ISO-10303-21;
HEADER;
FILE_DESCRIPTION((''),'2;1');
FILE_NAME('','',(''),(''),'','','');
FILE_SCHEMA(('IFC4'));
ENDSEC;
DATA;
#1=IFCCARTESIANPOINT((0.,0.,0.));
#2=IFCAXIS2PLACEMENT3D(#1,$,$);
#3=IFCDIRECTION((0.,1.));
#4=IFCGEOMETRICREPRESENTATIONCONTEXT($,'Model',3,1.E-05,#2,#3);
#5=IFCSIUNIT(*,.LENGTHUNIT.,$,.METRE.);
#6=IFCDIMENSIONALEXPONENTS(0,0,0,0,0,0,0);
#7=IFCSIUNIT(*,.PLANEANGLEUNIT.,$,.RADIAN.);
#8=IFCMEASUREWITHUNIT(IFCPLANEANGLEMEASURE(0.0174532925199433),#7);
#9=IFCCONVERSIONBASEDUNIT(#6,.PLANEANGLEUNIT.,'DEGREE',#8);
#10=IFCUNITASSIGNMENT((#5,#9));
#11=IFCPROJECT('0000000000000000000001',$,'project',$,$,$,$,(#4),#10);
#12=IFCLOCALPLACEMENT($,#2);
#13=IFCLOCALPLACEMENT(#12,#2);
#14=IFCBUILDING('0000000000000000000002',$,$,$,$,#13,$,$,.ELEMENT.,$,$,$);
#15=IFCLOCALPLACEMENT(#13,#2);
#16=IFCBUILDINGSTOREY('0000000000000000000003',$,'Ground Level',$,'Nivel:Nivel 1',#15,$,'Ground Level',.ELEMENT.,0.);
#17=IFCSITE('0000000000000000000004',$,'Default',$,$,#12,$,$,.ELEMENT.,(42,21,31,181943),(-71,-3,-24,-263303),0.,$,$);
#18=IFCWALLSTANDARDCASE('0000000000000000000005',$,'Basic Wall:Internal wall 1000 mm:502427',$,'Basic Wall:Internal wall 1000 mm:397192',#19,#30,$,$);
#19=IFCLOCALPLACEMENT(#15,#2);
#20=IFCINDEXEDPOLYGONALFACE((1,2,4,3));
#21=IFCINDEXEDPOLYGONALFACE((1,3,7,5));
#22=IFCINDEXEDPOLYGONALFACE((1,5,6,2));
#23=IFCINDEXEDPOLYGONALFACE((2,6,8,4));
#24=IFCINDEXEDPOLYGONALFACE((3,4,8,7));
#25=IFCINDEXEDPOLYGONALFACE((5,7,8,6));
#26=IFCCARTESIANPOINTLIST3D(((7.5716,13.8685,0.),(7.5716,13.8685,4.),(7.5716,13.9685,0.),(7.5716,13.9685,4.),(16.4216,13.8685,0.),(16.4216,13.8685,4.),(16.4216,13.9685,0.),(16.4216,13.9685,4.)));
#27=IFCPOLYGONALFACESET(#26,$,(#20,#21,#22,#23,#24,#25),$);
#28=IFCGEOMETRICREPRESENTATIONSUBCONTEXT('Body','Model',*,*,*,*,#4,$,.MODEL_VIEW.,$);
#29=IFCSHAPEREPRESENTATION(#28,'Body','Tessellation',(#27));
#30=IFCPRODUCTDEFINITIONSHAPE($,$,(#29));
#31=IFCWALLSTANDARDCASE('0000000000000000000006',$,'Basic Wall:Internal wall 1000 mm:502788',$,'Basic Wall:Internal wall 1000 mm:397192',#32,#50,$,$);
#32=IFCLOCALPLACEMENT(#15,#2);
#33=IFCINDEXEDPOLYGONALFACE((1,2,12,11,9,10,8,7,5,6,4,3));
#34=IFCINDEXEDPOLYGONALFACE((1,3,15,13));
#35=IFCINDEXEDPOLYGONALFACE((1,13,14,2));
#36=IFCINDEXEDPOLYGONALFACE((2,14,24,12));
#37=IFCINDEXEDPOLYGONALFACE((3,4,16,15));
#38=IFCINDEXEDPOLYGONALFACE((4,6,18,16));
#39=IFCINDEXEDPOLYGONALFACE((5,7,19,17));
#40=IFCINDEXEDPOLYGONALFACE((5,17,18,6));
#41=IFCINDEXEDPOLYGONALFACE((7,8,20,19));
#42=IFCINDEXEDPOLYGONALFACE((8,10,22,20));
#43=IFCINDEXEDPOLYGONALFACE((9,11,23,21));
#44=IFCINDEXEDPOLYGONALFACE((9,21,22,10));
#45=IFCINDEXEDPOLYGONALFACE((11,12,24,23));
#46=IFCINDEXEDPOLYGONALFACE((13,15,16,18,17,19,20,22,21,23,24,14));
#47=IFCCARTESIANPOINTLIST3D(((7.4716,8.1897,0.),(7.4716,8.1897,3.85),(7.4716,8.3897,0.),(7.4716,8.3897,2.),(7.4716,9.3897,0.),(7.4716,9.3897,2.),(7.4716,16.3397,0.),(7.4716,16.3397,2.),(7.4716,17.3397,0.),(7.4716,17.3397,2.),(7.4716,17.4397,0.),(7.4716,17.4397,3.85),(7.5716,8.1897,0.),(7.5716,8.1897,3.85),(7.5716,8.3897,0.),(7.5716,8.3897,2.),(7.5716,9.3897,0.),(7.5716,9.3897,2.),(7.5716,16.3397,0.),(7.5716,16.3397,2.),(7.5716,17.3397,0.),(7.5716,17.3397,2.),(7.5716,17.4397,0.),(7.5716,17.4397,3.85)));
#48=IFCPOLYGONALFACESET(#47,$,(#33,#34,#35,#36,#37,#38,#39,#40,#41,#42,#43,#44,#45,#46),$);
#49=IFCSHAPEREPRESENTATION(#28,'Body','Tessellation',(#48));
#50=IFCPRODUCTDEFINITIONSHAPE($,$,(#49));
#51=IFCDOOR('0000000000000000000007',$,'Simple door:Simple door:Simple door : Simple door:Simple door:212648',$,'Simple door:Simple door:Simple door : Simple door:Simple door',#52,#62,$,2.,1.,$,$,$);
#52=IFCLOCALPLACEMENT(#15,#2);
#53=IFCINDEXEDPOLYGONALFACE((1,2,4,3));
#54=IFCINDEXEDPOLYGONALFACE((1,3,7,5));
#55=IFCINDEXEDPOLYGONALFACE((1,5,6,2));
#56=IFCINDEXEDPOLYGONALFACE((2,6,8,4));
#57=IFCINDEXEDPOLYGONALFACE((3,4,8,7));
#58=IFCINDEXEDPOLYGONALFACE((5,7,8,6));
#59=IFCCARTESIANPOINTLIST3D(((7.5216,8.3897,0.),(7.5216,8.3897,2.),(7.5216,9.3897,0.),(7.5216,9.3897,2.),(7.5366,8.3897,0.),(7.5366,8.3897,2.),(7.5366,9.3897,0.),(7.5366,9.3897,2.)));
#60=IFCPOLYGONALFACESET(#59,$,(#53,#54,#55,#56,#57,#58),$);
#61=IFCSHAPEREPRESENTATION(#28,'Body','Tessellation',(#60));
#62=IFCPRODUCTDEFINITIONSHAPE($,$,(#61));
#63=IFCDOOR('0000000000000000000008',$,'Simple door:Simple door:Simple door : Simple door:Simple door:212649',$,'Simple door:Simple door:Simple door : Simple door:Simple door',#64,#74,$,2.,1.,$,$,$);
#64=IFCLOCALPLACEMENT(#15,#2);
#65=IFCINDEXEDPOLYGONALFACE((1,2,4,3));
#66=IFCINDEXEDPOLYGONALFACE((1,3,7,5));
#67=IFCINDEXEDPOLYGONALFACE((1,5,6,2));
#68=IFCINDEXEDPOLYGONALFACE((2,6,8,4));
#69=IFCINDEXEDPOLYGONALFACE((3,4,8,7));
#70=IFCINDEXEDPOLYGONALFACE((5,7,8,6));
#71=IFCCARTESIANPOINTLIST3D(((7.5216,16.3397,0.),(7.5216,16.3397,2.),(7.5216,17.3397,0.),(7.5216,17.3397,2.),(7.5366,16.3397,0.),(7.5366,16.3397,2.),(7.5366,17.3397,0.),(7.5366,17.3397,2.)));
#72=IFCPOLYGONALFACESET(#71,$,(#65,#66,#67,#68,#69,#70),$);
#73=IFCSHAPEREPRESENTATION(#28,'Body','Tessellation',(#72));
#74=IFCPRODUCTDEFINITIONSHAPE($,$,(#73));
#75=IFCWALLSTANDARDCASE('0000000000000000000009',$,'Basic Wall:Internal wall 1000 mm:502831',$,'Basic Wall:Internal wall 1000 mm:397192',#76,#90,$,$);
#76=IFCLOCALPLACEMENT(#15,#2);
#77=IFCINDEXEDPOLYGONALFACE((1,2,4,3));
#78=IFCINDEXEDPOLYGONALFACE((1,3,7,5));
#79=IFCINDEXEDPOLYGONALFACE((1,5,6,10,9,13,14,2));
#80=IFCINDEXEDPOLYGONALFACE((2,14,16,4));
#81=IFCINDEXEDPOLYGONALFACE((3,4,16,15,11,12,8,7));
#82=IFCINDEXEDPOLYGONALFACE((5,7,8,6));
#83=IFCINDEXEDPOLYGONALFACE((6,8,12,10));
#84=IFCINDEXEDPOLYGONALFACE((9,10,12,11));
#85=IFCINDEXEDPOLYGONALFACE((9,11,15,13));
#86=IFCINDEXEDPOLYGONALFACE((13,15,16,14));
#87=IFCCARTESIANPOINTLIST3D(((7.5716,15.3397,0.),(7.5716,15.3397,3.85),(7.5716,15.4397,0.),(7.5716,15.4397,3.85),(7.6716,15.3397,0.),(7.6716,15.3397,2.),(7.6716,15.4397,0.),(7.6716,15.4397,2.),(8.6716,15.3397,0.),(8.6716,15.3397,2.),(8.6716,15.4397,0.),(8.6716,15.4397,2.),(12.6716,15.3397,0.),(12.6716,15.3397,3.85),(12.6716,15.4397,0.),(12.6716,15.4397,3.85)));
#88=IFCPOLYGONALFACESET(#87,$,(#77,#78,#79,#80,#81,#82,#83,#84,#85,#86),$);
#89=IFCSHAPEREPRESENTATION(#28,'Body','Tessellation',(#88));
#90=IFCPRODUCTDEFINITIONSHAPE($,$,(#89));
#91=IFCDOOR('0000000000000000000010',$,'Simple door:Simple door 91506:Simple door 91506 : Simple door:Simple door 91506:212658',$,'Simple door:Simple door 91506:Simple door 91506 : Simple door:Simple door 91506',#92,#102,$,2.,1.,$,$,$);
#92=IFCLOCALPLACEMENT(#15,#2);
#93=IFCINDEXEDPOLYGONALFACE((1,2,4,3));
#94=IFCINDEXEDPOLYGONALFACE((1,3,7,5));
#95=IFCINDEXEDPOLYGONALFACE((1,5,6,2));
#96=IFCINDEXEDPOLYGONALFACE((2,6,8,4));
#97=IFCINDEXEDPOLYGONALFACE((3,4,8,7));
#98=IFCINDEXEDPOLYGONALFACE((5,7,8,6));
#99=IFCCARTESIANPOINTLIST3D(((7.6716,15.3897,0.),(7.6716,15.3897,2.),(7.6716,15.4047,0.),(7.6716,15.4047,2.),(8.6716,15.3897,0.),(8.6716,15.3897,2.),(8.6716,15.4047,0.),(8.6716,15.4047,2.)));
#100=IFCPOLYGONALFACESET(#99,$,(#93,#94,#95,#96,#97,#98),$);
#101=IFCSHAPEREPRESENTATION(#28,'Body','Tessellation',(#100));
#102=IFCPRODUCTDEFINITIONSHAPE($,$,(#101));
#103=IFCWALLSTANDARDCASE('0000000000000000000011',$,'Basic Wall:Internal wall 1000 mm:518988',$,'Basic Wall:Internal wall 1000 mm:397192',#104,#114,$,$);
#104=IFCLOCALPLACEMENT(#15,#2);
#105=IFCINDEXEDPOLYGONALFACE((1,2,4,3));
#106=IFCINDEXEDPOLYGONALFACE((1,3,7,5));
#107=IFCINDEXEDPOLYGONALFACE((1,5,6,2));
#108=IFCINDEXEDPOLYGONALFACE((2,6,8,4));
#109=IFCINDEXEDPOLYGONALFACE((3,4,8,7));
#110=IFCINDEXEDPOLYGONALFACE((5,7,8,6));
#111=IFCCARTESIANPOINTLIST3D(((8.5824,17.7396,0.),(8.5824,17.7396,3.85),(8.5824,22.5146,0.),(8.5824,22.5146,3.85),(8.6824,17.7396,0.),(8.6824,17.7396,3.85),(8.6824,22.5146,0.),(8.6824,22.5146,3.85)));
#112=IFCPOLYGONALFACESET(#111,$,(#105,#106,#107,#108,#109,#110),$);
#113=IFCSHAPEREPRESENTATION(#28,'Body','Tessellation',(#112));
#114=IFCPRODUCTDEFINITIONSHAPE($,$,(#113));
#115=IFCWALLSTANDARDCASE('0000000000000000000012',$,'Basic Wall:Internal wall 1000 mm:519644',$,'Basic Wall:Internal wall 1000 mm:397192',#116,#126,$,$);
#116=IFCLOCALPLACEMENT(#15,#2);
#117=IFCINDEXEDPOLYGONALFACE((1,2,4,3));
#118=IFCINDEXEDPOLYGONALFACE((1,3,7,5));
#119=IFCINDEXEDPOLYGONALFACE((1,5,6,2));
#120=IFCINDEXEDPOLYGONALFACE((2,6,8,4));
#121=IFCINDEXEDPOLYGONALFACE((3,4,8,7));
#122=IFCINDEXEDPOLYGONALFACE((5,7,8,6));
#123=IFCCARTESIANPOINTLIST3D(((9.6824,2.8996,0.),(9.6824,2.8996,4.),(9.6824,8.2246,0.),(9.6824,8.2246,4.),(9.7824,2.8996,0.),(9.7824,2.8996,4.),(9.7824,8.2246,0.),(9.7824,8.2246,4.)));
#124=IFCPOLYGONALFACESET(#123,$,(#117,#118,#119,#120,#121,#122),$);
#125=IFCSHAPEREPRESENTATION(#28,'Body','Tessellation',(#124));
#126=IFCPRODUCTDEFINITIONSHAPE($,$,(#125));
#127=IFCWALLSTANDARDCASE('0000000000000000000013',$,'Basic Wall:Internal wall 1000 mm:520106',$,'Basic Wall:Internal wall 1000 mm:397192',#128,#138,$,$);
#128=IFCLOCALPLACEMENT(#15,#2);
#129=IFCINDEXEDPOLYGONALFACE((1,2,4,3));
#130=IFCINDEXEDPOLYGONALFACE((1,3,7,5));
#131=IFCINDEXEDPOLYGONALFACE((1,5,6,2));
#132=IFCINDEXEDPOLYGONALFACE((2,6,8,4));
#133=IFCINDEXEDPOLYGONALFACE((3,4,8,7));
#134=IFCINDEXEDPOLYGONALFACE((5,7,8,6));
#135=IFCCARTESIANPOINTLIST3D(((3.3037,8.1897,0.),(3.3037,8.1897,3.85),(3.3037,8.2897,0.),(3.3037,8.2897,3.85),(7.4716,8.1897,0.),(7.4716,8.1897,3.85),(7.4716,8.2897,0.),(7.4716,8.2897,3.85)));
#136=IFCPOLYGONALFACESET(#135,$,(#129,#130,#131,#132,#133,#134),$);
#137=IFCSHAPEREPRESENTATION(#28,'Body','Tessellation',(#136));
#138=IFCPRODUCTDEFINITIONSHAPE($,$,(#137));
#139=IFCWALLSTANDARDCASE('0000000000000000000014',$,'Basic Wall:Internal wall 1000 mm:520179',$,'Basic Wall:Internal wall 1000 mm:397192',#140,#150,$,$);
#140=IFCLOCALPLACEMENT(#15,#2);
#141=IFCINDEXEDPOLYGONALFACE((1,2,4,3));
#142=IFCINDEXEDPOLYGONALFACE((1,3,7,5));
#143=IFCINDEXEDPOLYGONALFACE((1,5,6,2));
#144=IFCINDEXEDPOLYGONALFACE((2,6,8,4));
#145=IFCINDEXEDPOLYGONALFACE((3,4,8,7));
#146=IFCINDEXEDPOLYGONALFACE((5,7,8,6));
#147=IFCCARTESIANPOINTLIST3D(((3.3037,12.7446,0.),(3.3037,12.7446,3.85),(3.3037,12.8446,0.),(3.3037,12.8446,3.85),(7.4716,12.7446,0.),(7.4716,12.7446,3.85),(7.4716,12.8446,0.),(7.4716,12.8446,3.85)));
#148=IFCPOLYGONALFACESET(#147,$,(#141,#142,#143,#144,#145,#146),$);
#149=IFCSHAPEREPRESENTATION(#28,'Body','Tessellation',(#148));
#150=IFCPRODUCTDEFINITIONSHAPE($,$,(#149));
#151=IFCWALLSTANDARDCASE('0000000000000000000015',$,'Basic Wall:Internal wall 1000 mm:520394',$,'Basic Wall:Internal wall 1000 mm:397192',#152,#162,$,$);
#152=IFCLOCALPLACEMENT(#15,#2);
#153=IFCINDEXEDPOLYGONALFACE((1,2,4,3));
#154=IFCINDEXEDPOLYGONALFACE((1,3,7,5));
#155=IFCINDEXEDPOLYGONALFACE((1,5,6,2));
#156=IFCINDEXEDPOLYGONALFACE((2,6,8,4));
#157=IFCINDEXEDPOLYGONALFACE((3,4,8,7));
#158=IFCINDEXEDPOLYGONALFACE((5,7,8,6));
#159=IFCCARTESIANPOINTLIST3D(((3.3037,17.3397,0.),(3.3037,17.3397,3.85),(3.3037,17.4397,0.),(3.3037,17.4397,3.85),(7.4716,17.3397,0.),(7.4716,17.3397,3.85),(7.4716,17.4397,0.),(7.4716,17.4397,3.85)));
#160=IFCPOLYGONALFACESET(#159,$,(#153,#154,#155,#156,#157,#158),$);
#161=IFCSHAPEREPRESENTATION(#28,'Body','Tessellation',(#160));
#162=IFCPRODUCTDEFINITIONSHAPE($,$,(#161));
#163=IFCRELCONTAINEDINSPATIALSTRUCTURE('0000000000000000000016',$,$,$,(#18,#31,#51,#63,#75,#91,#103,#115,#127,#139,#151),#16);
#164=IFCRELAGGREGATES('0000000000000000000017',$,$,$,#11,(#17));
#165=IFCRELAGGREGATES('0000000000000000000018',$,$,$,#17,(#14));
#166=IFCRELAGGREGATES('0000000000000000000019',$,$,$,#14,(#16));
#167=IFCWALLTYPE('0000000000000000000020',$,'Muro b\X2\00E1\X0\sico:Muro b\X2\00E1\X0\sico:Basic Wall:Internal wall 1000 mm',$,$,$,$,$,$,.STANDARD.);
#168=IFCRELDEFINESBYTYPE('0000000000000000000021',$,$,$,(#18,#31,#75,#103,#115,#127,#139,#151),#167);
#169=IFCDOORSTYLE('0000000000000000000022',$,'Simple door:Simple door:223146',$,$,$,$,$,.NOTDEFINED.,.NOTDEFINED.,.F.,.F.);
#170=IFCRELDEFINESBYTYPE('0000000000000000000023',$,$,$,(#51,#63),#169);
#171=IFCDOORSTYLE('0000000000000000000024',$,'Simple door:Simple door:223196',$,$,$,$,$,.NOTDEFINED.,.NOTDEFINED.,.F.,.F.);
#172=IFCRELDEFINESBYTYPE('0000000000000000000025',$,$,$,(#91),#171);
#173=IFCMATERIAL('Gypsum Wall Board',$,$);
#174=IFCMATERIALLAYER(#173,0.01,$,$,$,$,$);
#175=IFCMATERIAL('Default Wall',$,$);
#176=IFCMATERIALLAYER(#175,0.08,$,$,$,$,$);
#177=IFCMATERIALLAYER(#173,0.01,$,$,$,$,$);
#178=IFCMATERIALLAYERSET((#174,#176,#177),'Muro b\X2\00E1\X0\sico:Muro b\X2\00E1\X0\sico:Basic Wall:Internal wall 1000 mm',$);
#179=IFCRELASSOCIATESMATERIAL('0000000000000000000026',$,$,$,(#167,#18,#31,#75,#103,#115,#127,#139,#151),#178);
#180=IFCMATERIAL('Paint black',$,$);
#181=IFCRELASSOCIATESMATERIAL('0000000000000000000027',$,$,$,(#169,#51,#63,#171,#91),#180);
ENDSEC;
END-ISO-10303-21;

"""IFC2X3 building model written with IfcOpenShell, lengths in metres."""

from ifc_helpers import new_model, entity, si_unit, converted_unit, direction, frame, frame_2d, origin, origin_2d_with_axis, place, context, subcontext, project, spatial, rectangle, extrude, source, transform, mapped, material, layer, layer_set, layer_usage, type_object, type_shapes, element, fill, save


model = new_model("IFC2X3")

# Units and contexts
model_context = context("Model", 3, precision=1e-05, world=origin(), true_north=direction((0.0, 1.0)))
body_context = subcontext(model_context, "Body", "Model", "MODEL_VIEW")
ifc_project = project(units=[si_unit("LENGTHUNIT", "METRE"), converted_unit("PLANEANGLEUNIT", "DEGREE", entity("IfcPlaneAngleMeasure", 0.0174532925199433), si_unit("PLANEANGLEUNIT", "RADIAN"), dimensions=[0, 0, 0, 0, 0, 0, 0])], contexts=[model_context])

# Site, building, storey
site_placement = place(None, origin())
site = spatial("IfcSite", under=ifc_project, at=site_placement, Name="Default", CompositionType="ELEMENT", RefLatitude=(42, 21, 31, 181943), RefLongitude=(-71, -3, -24, -263303), RefElevation=0.0)
building_placement = place(site_placement, origin())
building = spatial("IfcBuilding", under=site, at=building_placement, CompositionType="ELEMENT")
storey_placement = place(building_placement, origin())
storey = spatial("IfcBuildingStorey", under=building, at=storey_placement, Name="Ground Level", ObjectType="Nivel:Nivel 1", LongName="Ground Level", CompositionType="ELEMENT", Elevation=0.0)

# Wall
ifc_material_1 = material(Name="Gypsum Wall Board")
ifc_layer_1 = layer(ifc_material_1, 0.01)
ifc_material_2 = material(Name="Default Wall")
ifc_layer_2 = layer(ifc_material_2, 0.08)
ifc_layer_3 = layer(ifc_material_1, 0.01)
ifc_layer_set_1 = layer_set([ifc_layer_1, ifc_layer_2, ifc_layer_3], Name="Muro básico:Muro básico:Basic Wall:Internal wall 1000 mm")
ifc_layer_usage_1 = layer_usage(ifc_layer_set_1, "AXIS2", "NEGATIVE", 0.05)
wall_type = type_object("IfcWallType", Name="Muro básico:Muro básico:Basic Wall:Internal wall 1000 mm", PredefinedType="STANDARD", material=ifc_layer_set_1)
wall_1_placement = place(storey_placement, frame((7.5716, 13.9185, 0.0)))
element("IfcWallStandardCase", 1, at=wall_1_placement, inside=storey, type_object=wall_type, material=ifc_layer_usage_1, Name="Basic Wall:Internal wall 1000 mm:502427", ObjectType="Basic Wall:Internal wall 1000 mm:397192", context=body_context, shape_type="SweptSolid", body=[
    extrude(rectangle(XDim=8.85, YDim=0.1, at=frame_2d((4.425, 0.0), x_axis=(-1.0, 0.0))), origin(), (0.0, 0.0, 1.0), 4.0),
])

# Wall, openings, doors
ifc_material_3 = material(Name="Paint black")
door_style_1 = type_object("IfcDoorStyle", Name="Simple door:Simple door:223146", ConstructionType="NOTDEFINED", OperationType="NOTDEFINED", ParameterTakesPrecedence=False, Sizeable=False, material=ifc_material_3)
shared_shape_1 = source(origin(), body_context, "Body", "SweptSolid", [
    extrude(rectangle(XDim=1.0, YDim=0.015, at=origin_2d_with_axis()), frame((0.5, -0.0595, 0.0)), (0.0, 0.0, 1.0), 2.0),
])
type_shapes(door_style_1, [shared_shape_1])
ifc_layer_usage_2 = layer_usage(ifc_layer_set_1, "AXIS2", "NEGATIVE", 0.05)
wall_2_placement = place(storey_placement, frame((7.5216, 8.1897, 0.0), z_axis=(0.0, 0.0, 1.0), x_axis=(0.0, 1.0, 0.0)))
wall_2 = element("IfcWallStandardCase", 2, at=wall_2_placement, inside=storey, type_object=wall_type, material=ifc_layer_usage_2, Name="Basic Wall:Internal wall 1000 mm:502788", ObjectType="Basic Wall:Internal wall 1000 mm:397192", context=body_context, shape_type="SweptSolid", body=[
    extrude(rectangle(XDim=9.25, YDim=0.1, at=frame_2d((4.625, 0.0), x_axis=(1.0, 0.0))), origin(), (0.0, 0.0, 1.0), 3.85),
])
opening_1_placement = place(wall_2_placement, frame((-8.1897, 7.5216, 0.0), z_axis=(0.0, 0.0, 1.0), x_axis=(0.0, -1.0, 0.0)))
opening_1 = element("IfcOpeningElement", 3, at=opening_1_placement, cuts=wall_2, ObjectType="Opening", context=body_context, shape_type="SweptSolid", body=[
    extrude(rectangle(XDim=2.0, YDim=1.0, at=frame_2d((0.0, 0.0), x_axis=(0.0, 1.0))), frame((7.5736, 8.8897, 1.0), z_axis=(-1.0, 0.0, 0.0), x_axis=(0.0, -1.0, 0.0)), (0.0, 0.0, 1.0), 0.104),
])
opening_2_placement = place(wall_2_placement, frame((-8.1897, 7.5216, 0.0), z_axis=(0.0, 0.0, 1.0), x_axis=(0.0, -1.0, 0.0)))
opening_2 = element("IfcOpeningElement", 4, at=opening_2_placement, cuts=wall_2, ObjectType="Opening", context=body_context, shape_type="SweptSolid", body=[
    extrude(rectangle(XDim=2.0, YDim=1.0, at=frame_2d((0.0, 0.0), x_axis=(0.0, 1.0))), frame((7.5736, 16.8397, 1.0), z_axis=(-1.0, 0.0, 0.0), x_axis=(0.0, -1.0, 0.0)), (0.0, 0.0, 1.0), 0.104),
])
door_1_placement = place(opening_1_placement, frame((7.4696, 8.3897, 0.0), z_axis=(0.0, 0.0, 1.0), x_axis=(0.0, 1.0, 0.0)))
door_1 = element("IfcDoor", 5, at=door_1_placement, inside=storey, type_object=door_style_1, material=ifc_material_3, Name="Simple door:Simple door:Simple door : Simple door:Simple door:212648", ObjectType="Simple door:Simple door:Simple door : Simple door:Simple door", OverallHeight=2.0, OverallWidth=1.0, context=body_context, shape_type="MappedRepresentation", body=[
    mapped(shared_shape_1, transform((0.0, 0.0, 0.0), scale=1.0)),
])
fill(opening_1, door_1)
door_2_placement = place(opening_2_placement, frame((7.4696, 16.3397, 0.0), z_axis=(0.0, 0.0, 1.0), x_axis=(0.0, 1.0, 0.0)))
door_2 = element("IfcDoor", 6, at=door_2_placement, inside=storey, type_object=door_style_1, material=ifc_material_3, Name="Simple door:Simple door:Simple door : Simple door:Simple door:212649", ObjectType="Simple door:Simple door:Simple door : Simple door:Simple door", OverallHeight=2.0, OverallWidth=1.0, context=body_context, shape_type="MappedRepresentation", body=[
    mapped(shared_shape_1, transform((0.0, 0.0, 0.0), scale=1.0)),
])
fill(opening_2, door_2)

# Wall, opening, door
ifc_layer_usage_3 = layer_usage(ifc_layer_set_1, "AXIS2", "NEGATIVE", 0.05)
wall_3_placement = place(storey_placement, frame((7.5716, 15.3897, 0.0)))
wall_3 = element("IfcWallStandardCase", 7, at=wall_3_placement, inside=storey, type_object=wall_type, material=ifc_layer_usage_3, Name="Basic Wall:Internal wall 1000 mm:502831", ObjectType="Basic Wall:Internal wall 1000 mm:397192", context=body_context, shape_type="SweptSolid", body=[
    extrude(rectangle(XDim=5.1, YDim=0.1, at=frame_2d((2.55, 0.0), x_axis=(-1.0, 0.0))), origin(), (0.0, 0.0, 1.0), 3.85),
])
opening_3_placement = place(wall_3_placement, frame((-7.5716, -15.3897, 0.0)))
opening_3 = element("IfcOpeningElement", 8, at=opening_3_placement, cuts=wall_3, ObjectType="Opening", context=body_context, shape_type="SweptSolid", body=[
    extrude(rectangle(XDim=2.0, YDim=1.0, at=frame_2d((0.0, 0.0), x_axis=(0.0, 1.0))), frame((8.1716, 15.3377, 1.0), z_axis=(0.0, 1.0, 0.0), x_axis=(-1.0, 0.0, 0.0)), (0.0, 0.0, 1.0), 0.104),
])
door_style_2 = type_object("IfcDoorStyle", Name="Simple door:Simple door:223196", ConstructionType="NOTDEFINED", OperationType="NOTDEFINED", ParameterTakesPrecedence=False, Sizeable=False, material=ifc_material_3)
shared_shape_2 = source(origin(), body_context, "Body", "SweptSolid", [
    extrude(rectangle(XDim=1.0, YDim=0.015, at=origin_2d_with_axis()), frame((0.5, 0.0445, 0.0)), (0.0, 0.0, 1.0), 2.0),
])
type_shapes(door_style_2, [shared_shape_2])
door_3_placement = place(opening_3_placement, frame((8.6716, 15.4417, 0.0), z_axis=(0.0, 0.0, 1.0), x_axis=(-1.0, 0.0, 0.0)))
door_3 = element("IfcDoor", 9, at=door_3_placement, inside=storey, type_object=door_style_2, material=ifc_material_3, Name="Simple door:Simple door 91506:Simple door 91506 : Simple door:Simple door 91506:212658", ObjectType="Simple door:Simple door 91506:Simple door 91506 : Simple door:Simple door 91506", OverallHeight=2.0, OverallWidth=1.0, context=body_context, shape_type="MappedRepresentation", body=[
    mapped(shared_shape_2, transform((0.0, 0.0, 0.0), scale=1.0)),
])
fill(opening_3, door_3)

# Walls
ifc_layer_usage_4 = layer_usage(ifc_layer_set_1, "AXIS2", "NEGATIVE", 0.05)
wall_4_placement = place(storey_placement, frame((8.6324, 22.5146, 0.0), z_axis=(0.0, 0.0, 1.0), x_axis=(0.0, -1.0, 0.0)))
element("IfcWallStandardCase", 10, at=wall_4_placement, inside=storey, type_object=wall_type, material=ifc_layer_usage_4, Name="Basic Wall:Internal wall 1000 mm:518988", ObjectType="Basic Wall:Internal wall 1000 mm:397192", context=body_context, shape_type="SweptSolid", body=[
    extrude(rectangle(XDim=4.775, YDim=0.1, at=frame_2d((2.3875, 0.0), x_axis=(-1.0, 0.0))), origin(), (0.0, 0.0, 1.0), 3.85),
])
ifc_layer_usage_5 = layer_usage(ifc_layer_set_1, "AXIS2", "NEGATIVE", 0.05)
wall_5_placement = place(storey_placement, frame((9.7324, 2.8996, 0.0), z_axis=(0.0, 0.0, 1.0), x_axis=(0.0, 1.0, 0.0)))
element("IfcWallStandardCase", 11, at=wall_5_placement, inside=storey, type_object=wall_type, material=ifc_layer_usage_5, Name="Basic Wall:Internal wall 1000 mm:519644", ObjectType="Basic Wall:Internal wall 1000 mm:397192", context=body_context, shape_type="SweptSolid", body=[
    extrude(rectangle(XDim=5.325, YDim=0.1, at=frame_2d((2.6625, 0.0), x_axis=(-1.0, 0.0))), origin(), (0.0, 0.0, 1.0), 4.0),
])
ifc_layer_usage_6 = layer_usage(ifc_layer_set_1, "AXIS2", "NEGATIVE", 0.05)
wall_6_placement = place(storey_placement, frame((7.4716, 8.2397, 0.0), z_axis=(0.0, 0.0, 1.0), x_axis=(-1.0, 0.0, 0.0)))
element("IfcWallStandardCase", 12, at=wall_6_placement, inside=storey, type_object=wall_type, material=ifc_layer_usage_6, Name="Basic Wall:Internal wall 1000 mm:520106", ObjectType="Basic Wall:Internal wall 1000 mm:397192", context=body_context, shape_type="SweptSolid", body=[
    extrude(rectangle(XDim=4.1679, YDim=0.1, at=frame_2d((2.0839, 0.0), x_axis=(-1.0, 0.0))), origin(), (0.0, 0.0, 1.0), 3.85),
])
ifc_layer_usage_7 = layer_usage(ifc_layer_set_1, "AXIS2", "NEGATIVE", 0.05)
wall_7_placement = place(storey_placement, frame((7.4716, 12.7946, 0.0), z_axis=(0.0, 0.0, 1.0), x_axis=(-1.0, 0.0, 0.0)))
element("IfcWallStandardCase", 13, at=wall_7_placement, inside=storey, type_object=wall_type, material=ifc_layer_usage_7, Name="Basic Wall:Internal wall 1000 mm:520179", ObjectType="Basic Wall:Internal wall 1000 mm:397192", context=body_context, shape_type="SweptSolid", body=[
    extrude(rectangle(XDim=4.1679, YDim=0.1, at=frame_2d((2.0839, 0.0), x_axis=(-1.0, 0.0))), origin(), (0.0, 0.0, 1.0), 3.85),
])
ifc_layer_usage_8 = layer_usage(ifc_layer_set_1, "AXIS2", "NEGATIVE", 0.05)
wall_8_placement = place(storey_placement, frame((7.4716, 17.3897, 0.0), z_axis=(0.0, 0.0, 1.0), x_axis=(-1.0, 0.0, 0.0)))
element("IfcWallStandardCase", 14, at=wall_8_placement, inside=storey, type_object=wall_type, material=ifc_layer_usage_8, Name="Basic Wall:Internal wall 1000 mm:520394", ObjectType="Basic Wall:Internal wall 1000 mm:397192", context=body_context, shape_type="SweptSolid", body=[
    extrude(rectangle(XDim=4.1679, YDim=0.1, at=frame_2d((2.0839, 0.0), x_axis=(-1.0, 0.0))), origin(), (0.0, 0.0, 1.0), 3.85),
])

save(model, "model.ifc")
